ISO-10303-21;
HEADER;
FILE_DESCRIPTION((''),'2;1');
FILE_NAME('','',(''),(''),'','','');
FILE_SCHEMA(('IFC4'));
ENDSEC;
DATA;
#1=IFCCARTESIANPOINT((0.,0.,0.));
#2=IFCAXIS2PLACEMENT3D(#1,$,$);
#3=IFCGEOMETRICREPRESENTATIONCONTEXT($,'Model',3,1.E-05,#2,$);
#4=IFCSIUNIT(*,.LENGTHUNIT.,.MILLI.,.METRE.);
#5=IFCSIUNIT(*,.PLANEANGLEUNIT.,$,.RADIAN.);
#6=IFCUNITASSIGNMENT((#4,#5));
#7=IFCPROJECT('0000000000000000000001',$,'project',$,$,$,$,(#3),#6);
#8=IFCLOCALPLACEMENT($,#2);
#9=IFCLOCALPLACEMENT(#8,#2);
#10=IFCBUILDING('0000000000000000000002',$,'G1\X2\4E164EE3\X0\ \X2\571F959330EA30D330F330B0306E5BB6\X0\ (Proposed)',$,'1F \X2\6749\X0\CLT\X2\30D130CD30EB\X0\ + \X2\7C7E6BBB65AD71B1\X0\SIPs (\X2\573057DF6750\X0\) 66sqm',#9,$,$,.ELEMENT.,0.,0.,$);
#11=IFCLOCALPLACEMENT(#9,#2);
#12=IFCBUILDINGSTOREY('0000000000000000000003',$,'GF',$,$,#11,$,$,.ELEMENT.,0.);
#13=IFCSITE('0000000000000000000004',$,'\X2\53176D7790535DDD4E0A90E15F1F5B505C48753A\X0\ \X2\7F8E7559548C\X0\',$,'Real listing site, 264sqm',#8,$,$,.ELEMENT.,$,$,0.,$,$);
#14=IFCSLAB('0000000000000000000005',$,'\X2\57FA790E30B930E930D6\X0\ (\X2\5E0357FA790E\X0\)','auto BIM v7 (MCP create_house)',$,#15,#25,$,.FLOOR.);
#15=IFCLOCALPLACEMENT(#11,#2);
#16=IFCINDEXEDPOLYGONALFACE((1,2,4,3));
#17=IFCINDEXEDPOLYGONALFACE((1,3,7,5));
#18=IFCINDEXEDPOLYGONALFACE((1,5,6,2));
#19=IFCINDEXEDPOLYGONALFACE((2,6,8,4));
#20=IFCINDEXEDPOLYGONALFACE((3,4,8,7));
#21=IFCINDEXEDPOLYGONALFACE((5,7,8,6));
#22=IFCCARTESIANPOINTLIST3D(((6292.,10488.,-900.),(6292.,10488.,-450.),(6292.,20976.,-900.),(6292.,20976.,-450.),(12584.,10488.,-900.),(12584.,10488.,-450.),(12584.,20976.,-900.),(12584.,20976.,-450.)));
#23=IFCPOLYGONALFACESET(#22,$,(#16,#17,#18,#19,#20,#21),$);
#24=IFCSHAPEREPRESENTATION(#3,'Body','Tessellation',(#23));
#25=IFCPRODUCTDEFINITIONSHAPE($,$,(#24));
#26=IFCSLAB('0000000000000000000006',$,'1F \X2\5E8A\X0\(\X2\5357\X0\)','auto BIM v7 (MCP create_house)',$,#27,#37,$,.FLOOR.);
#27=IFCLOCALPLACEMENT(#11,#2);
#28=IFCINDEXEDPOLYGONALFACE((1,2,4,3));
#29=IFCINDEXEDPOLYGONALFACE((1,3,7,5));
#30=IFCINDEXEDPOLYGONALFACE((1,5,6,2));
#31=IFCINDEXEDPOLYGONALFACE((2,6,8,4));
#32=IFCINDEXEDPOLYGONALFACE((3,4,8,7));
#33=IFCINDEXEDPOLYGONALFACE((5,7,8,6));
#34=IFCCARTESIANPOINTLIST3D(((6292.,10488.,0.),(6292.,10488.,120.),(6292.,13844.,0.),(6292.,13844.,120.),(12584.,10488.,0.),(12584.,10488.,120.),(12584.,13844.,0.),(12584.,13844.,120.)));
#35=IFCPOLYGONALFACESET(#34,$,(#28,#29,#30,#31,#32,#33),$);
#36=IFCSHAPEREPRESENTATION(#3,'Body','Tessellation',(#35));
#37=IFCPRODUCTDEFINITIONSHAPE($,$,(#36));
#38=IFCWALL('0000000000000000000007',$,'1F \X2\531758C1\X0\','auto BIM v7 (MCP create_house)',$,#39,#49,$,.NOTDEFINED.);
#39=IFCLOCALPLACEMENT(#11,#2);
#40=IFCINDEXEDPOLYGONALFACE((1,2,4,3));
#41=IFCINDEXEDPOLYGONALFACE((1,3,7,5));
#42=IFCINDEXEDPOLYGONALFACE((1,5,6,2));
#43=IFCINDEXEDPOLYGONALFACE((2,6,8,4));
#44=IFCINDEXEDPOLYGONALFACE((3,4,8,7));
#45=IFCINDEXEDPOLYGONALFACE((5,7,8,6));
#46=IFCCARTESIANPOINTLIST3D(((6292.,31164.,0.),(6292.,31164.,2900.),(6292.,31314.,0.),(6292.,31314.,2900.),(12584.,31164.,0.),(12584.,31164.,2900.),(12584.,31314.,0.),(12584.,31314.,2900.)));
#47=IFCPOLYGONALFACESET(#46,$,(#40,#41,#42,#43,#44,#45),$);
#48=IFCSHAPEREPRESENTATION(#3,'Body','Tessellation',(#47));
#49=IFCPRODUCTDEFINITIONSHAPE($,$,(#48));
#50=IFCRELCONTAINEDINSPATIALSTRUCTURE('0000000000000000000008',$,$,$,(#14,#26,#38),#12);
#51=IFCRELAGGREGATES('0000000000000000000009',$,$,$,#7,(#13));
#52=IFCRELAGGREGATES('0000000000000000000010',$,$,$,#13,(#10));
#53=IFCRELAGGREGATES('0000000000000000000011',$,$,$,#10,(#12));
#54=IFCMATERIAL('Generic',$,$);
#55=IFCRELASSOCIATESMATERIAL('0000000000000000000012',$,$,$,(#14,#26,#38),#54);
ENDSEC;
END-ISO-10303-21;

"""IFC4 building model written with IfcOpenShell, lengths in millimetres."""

from ifc_helpers import new_model, si_unit, frame, frame_2d, origin, place, context, project, spatial, rectangle, extrude, material, element, save


model = new_model("IFC4")

# Units and contexts
model_context = context("Model", 3, precision=1e-05, world=origin())
ifc_project = project(units=[si_unit("LENGTHUNIT", "METRE", prefix="MILLI"), si_unit("PLANEANGLEUNIT", "RADIAN")], contexts=[model_context])

# Site, building, storey
site_placement = place(None, origin())
site = spatial("IfcSite", under=ifc_project, at=site_placement, Name="北海道川上郡弟子屈町 美留和", ObjectType="Real listing site, 264sqm", CompositionType="ELEMENT", RefElevation=0.0)
building_placement = place(site_placement, origin())
building = spatial("IfcBuilding", under=site, at=building_placement, Name="G1世代 土間リビングの家 (Proposed)", ObjectType="1F 杉CLTパネル + 籾殻断熱SIPs (地域材) 66sqm", CompositionType="ELEMENT", ElevationOfRefHeight=0.0, ElevationOfTerrain=0.0)
storey_placement = place(building_placement, origin())
storey = spatial("IfcBuildingStorey", under=building, at=storey_placement, Name="GF", CompositionType="ELEMENT", Elevation=0.0)

# Slabs
ifc_material = material(Name="Generic")
slab_1_placement = place(storey_placement, frame((3146.0, 5244.0, -450.0)))
element("IfcSlab", 1, at=slab_1_placement, inside=storey, material=ifc_material, Name="基礎スラブ (布基礎)", Description="auto BIM v7 (MCP create_house)", PredefinedType="FLOOR", context=model_context, shape_type="SweptSolid", body=[
    extrude(rectangle(XDim=6292.0, YDim=10488.0, at=frame_2d((3146.0, 5244.0))), frame((3146.0, 5244.0, -450.0)), (0.0, 0.0, 1.0), 450.0),
])
slab_2_placement = place(storey_placement, frame((3146.0, 5244.0, 0.0)))
element("IfcSlab", 2, at=slab_2_placement, inside=storey, material=ifc_material, Name="1F 床(南)", Description="auto BIM v7 (MCP create_house)", PredefinedType="FLOOR", context=model_context, shape_type="SweptSolid", body=[
    extrude(rectangle(XDim=6292.0, YDim=3356.0, at=frame_2d((3146.0, 1678.0))), frame((3146.0, 5244.0, 0.0)), (0.0, 0.0, 1.0), 120.0),
])

# Wall
wall_1_placement = place(storey_placement, frame((3146.0, 15582.0, 0.0)))
element("IfcWall", 3, at=wall_1_placement, inside=storey, material=ifc_material, Name="1F 北壁", Description="auto BIM v7 (MCP create_house)", PredefinedType="NOTDEFINED", context=model_context, shape_type="SweptSolid", body=[
    extrude(rectangle(XDim=6292.0, YDim=150.0, at=frame_2d((3146.0, 75.0))), frame((3146.0, 15582.0, 0.0)), (0.0, 0.0, 1.0), 2900.0),
])

save(model, "model.ifc")
